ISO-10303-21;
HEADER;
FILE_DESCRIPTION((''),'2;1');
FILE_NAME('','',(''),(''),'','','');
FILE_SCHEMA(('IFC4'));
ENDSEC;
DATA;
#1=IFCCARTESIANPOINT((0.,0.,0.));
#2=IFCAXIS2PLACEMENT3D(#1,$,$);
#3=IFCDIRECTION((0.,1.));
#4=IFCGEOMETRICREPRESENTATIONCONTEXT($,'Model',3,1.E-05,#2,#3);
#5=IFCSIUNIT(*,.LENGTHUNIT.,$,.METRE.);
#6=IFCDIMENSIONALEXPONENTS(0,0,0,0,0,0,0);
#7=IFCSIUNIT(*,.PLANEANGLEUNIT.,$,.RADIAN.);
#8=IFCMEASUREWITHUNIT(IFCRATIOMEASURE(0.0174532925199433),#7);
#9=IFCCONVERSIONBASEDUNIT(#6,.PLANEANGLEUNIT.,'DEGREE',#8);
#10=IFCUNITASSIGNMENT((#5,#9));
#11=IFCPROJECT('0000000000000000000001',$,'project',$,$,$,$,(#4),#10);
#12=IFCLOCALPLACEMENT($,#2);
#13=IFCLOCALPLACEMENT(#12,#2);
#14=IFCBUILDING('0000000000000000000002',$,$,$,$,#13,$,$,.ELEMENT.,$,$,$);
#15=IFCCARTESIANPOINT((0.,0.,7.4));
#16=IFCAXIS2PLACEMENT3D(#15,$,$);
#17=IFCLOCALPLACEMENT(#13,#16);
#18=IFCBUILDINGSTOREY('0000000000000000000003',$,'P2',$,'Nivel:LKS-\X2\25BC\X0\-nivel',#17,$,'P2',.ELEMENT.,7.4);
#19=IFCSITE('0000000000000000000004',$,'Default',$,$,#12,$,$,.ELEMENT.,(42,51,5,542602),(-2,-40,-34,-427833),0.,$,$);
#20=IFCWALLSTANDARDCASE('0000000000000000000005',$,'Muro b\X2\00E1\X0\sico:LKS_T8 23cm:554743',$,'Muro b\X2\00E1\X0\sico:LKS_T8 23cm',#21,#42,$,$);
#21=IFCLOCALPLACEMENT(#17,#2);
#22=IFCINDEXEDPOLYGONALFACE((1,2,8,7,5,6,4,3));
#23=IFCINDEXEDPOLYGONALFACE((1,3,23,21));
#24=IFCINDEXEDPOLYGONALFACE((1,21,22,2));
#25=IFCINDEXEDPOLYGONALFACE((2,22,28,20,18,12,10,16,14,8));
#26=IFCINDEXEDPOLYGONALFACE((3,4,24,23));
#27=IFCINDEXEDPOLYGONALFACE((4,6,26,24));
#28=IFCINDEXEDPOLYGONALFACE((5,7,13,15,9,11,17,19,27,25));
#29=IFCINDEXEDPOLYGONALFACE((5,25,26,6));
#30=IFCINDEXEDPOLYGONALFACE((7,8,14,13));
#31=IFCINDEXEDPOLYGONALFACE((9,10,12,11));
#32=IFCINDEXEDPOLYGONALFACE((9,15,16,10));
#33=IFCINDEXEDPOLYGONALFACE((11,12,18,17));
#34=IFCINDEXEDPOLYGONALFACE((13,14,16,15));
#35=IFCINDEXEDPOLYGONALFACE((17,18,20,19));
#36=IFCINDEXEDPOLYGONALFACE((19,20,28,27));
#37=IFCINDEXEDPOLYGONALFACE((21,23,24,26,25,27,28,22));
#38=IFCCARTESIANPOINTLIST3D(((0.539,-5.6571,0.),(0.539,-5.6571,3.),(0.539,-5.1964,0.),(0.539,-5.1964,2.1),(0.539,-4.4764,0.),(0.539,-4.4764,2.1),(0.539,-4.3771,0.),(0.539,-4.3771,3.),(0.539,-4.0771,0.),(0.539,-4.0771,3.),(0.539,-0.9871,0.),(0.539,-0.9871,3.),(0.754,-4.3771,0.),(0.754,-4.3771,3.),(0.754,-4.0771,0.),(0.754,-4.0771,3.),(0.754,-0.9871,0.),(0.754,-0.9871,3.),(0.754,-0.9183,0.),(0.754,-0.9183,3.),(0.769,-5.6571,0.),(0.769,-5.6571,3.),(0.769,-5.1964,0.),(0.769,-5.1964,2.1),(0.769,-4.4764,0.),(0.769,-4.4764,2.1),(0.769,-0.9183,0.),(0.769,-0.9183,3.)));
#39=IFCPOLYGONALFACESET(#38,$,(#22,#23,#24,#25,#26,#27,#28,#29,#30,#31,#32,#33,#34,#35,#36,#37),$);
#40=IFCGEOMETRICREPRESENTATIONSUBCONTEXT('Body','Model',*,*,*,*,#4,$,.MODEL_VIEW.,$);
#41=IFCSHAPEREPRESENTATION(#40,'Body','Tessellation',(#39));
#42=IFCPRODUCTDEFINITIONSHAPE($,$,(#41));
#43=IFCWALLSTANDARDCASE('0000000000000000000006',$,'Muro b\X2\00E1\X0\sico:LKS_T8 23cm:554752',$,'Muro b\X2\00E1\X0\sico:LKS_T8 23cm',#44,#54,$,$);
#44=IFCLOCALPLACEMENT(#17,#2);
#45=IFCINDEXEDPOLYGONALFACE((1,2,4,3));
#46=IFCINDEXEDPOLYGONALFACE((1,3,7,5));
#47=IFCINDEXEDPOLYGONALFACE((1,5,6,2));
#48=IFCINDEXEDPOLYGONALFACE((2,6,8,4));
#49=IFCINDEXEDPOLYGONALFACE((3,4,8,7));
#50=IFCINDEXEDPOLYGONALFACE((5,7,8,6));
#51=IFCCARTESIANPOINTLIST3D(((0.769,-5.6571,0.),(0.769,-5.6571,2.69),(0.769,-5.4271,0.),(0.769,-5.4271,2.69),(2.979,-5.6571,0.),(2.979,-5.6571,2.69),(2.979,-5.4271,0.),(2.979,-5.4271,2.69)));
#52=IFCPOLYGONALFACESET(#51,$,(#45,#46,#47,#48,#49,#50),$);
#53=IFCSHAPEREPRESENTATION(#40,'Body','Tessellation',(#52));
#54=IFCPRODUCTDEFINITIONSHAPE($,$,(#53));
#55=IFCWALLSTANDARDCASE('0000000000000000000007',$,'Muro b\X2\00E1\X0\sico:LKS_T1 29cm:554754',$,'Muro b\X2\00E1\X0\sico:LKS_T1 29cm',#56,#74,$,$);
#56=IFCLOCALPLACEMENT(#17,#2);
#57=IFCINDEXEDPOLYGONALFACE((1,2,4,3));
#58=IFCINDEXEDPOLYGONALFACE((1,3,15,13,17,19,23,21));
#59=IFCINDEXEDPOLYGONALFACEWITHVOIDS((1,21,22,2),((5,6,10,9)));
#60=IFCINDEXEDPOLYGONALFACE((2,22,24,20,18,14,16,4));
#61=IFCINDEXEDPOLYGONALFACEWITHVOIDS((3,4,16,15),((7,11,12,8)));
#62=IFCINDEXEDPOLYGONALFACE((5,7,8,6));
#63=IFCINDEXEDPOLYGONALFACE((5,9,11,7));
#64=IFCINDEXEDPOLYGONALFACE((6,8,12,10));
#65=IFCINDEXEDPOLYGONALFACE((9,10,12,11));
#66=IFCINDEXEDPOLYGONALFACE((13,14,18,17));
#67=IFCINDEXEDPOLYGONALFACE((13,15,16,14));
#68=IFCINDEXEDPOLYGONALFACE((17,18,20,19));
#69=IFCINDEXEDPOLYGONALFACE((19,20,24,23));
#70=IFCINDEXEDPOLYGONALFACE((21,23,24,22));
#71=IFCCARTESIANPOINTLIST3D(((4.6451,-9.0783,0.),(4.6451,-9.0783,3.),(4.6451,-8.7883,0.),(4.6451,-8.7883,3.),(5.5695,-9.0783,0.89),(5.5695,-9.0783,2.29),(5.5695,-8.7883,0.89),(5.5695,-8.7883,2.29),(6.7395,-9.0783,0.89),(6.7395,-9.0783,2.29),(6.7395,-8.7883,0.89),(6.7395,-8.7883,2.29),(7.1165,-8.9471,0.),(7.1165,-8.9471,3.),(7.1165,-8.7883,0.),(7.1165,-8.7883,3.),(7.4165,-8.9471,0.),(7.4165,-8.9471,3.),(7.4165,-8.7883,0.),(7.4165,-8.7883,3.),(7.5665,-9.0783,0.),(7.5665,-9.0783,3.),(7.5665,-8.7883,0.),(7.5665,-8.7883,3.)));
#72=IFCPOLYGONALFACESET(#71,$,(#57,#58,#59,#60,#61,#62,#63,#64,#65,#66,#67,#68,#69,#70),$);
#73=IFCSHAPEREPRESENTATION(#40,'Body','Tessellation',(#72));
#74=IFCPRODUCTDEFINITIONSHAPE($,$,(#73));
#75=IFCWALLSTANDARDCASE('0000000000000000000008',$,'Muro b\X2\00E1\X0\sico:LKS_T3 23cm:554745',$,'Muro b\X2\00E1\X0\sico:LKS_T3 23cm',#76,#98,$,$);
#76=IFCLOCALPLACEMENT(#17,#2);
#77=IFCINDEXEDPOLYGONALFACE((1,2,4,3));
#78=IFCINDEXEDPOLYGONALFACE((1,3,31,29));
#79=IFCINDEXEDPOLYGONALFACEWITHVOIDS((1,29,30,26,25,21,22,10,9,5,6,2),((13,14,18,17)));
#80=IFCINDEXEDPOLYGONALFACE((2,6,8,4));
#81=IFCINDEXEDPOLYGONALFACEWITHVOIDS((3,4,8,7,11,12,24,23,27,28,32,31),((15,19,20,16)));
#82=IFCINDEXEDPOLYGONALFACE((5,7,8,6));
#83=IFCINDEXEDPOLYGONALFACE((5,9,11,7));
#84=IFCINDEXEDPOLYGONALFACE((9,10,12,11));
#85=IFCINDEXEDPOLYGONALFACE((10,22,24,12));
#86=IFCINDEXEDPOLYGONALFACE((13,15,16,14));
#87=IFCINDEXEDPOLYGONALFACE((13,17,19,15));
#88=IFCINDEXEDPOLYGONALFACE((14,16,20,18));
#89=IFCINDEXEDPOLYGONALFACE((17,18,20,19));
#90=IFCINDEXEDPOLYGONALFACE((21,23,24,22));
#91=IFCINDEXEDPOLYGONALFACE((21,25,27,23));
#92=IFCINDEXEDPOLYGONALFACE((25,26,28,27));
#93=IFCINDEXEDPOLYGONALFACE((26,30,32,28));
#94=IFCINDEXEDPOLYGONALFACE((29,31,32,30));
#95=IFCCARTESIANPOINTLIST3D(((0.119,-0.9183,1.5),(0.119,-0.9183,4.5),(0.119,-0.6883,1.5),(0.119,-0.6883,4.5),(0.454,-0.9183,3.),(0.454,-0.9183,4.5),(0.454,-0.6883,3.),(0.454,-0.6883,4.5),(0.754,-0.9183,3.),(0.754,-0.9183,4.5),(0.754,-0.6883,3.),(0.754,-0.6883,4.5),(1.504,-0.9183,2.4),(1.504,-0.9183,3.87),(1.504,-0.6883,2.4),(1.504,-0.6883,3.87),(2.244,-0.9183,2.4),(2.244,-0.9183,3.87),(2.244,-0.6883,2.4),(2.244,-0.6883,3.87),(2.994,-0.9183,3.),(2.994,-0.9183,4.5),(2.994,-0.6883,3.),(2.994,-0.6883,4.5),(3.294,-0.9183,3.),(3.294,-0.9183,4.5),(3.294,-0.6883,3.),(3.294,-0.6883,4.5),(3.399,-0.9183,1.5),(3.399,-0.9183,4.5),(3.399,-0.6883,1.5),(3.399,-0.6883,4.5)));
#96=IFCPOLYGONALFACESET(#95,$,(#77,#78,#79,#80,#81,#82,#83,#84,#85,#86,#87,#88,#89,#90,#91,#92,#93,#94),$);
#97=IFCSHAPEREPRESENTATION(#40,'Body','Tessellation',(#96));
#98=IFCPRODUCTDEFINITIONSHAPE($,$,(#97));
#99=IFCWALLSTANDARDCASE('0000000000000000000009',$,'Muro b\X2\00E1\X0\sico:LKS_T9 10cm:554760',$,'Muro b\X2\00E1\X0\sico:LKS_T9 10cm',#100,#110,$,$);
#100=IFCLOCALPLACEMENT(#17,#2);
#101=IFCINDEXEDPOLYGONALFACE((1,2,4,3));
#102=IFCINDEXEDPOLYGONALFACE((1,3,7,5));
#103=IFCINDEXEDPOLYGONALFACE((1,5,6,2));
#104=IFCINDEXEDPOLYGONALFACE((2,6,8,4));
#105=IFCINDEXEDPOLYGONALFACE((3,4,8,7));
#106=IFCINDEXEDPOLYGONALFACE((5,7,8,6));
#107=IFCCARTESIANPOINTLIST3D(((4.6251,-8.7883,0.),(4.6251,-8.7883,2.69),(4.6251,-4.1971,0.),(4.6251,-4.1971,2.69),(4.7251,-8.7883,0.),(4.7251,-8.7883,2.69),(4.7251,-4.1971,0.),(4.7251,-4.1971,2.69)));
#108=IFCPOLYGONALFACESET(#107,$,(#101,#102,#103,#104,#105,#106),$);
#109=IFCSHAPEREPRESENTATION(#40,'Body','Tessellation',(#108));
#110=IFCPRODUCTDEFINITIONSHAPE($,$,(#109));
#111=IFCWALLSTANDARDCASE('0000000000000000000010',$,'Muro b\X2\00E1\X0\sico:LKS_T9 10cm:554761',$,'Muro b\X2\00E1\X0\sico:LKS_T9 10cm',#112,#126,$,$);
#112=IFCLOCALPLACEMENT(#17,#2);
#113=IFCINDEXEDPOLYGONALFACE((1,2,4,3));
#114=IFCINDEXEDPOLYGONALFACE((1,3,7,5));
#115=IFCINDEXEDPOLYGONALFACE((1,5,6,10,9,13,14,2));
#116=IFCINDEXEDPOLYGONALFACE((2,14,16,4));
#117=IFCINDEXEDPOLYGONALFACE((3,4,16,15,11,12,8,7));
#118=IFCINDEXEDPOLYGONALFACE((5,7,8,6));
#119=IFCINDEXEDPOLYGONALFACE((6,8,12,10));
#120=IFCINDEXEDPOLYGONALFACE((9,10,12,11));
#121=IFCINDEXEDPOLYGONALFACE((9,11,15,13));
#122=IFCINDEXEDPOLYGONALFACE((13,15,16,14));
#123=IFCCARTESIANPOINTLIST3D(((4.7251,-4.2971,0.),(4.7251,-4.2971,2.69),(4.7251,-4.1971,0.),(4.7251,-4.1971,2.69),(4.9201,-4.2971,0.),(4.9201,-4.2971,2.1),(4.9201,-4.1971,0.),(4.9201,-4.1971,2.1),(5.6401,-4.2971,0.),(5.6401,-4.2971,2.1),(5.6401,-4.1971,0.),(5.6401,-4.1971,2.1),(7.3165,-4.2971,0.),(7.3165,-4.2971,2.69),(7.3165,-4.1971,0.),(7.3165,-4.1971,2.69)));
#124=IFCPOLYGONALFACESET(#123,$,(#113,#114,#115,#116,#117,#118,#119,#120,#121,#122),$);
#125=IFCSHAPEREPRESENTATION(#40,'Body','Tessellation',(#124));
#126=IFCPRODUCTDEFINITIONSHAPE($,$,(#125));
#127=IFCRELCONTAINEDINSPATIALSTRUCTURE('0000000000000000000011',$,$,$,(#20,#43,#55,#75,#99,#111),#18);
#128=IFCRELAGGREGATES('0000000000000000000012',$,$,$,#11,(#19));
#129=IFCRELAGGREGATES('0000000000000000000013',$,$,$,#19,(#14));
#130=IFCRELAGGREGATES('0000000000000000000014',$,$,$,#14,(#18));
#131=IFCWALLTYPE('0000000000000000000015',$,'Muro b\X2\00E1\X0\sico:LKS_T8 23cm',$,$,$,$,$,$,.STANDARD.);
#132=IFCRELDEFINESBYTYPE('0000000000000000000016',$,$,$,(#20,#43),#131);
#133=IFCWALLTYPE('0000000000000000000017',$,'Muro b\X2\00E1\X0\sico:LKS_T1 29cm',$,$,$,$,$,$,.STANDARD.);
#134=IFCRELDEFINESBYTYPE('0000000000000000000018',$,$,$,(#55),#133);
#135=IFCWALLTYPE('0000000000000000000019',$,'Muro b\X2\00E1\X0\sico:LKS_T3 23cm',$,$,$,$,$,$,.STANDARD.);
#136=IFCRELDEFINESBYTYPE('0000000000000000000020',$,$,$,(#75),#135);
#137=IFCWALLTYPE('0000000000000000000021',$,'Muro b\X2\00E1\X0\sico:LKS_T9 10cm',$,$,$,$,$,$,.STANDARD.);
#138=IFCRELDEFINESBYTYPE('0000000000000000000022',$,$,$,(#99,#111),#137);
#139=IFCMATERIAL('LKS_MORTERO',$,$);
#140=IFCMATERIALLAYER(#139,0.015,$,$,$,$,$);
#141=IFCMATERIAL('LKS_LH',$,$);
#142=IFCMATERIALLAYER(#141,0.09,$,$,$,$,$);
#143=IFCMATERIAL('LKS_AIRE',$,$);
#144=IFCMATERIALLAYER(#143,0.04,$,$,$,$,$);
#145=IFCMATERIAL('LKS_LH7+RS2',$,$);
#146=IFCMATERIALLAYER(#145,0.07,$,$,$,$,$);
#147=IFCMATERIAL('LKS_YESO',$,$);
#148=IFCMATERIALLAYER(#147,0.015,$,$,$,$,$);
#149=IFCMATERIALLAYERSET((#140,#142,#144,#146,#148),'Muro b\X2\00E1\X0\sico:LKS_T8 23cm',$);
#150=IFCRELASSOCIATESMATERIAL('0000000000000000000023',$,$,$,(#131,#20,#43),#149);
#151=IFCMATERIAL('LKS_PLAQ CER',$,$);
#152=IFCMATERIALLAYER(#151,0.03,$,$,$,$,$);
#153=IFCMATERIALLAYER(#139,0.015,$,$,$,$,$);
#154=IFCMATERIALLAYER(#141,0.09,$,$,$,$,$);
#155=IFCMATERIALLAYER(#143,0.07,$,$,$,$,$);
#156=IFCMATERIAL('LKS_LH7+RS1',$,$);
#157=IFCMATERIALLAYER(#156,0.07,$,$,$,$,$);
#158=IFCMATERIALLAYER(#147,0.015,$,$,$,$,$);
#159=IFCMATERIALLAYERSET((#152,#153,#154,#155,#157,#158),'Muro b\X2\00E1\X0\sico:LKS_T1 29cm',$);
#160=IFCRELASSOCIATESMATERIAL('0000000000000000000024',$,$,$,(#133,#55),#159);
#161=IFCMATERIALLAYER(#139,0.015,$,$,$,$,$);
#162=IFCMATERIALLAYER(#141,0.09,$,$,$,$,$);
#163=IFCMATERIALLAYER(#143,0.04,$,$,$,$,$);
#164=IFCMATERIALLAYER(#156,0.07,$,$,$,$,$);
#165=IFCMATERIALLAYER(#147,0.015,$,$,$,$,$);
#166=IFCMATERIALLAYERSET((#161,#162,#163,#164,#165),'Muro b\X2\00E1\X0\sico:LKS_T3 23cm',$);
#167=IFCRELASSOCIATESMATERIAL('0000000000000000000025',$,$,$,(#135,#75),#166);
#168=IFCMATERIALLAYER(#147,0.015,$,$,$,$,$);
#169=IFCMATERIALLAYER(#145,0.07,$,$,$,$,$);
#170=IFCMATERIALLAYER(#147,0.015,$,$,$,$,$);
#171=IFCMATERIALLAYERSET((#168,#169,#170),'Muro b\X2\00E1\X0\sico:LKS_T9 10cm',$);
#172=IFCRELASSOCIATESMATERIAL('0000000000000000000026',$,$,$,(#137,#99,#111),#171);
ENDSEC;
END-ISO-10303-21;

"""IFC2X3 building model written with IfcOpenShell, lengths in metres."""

from ifc_helpers import new_model, entity, si_unit, converted_unit, direction, frame, frame_2d, origin, place, context, subcontext, project, spatial, polyline, rectangle, extrude, clip, bounded_halfspace, material, layer, layer_set, layer_usage, type_object, element, save


model = new_model("IFC2X3")

# Units and contexts
model_context = context("Model", 3, precision=1e-05, world=origin(), true_north=direction((0.0, 1.0)))
body_context = subcontext(model_context, "Body", "Model", "MODEL_VIEW")
ifc_project = project(units=[si_unit("LENGTHUNIT", "METRE"), converted_unit("PLANEANGLEUNIT", "DEGREE", entity("IfcRatioMeasure", 0.0174532925199433), si_unit("PLANEANGLEUNIT", "RADIAN"), dimensions=[0, 0, 0, 0, 0, 0, 0])], contexts=[model_context])

# Site, building, storey
site_placement = place(None, origin())
site = spatial("IfcSite", under=ifc_project, at=site_placement, Name="Default", CompositionType="ELEMENT", RefLatitude=(42, 51, 5, 542602), RefLongitude=(-2, -40, -34, -427833), RefElevation=0.0)
building_placement = place(site_placement, origin())
building = spatial("IfcBuilding", under=site, at=building_placement, CompositionType="ELEMENT")
storey_placement = place(building_placement, frame((0.0, 0.0, 7.4)))
storey = spatial("IfcBuildingStorey", under=building, at=storey_placement, Name="P2", ObjectType="Nivel:LKS-▼-nivel", LongName="P2", CompositionType="ELEMENT", Elevation=7.4)

# Shared definitions
ifc_material_1 = material(Name="LKS_MORTERO")
ifc_layer_1 = layer(ifc_material_1, 0.015)
ifc_material_2 = material(Name="LKS_LH")
ifc_layer_2 = layer(ifc_material_2, 0.09)
ifc_material_3 = material(Name="LKS_AIRE")
ifc_layer_3 = layer(ifc_material_3, 0.04)
ifc_material_4 = material(Name="LKS_LH7+RS2")
ifc_layer_4 = layer(ifc_material_4, 0.07)
ifc_material_5 = material(Name="LKS_YESO")
ifc_layer_5 = layer(ifc_material_5, 0.015)
ifc_layer_set_1 = layer_set([ifc_layer_1, ifc_layer_2, ifc_layer_3, ifc_layer_4, ifc_layer_5], Name="Muro básico:LKS_T8 23cm")
wall_type_1 = type_object("IfcWallType", Name="Muro básico:LKS_T8 23cm", PredefinedType="STANDARD", material=ifc_layer_set_1)

# Wall, openings
ifc_layer_usage_1 = layer_usage(ifc_layer_set_1, "AXIS2", "POSITIVE", -0.115)
wall_1_placement = place(storey_placement, frame((0.654, -5.6571, 0.0), z_axis=(0.0, 0.0, 1.0), x_axis=(0.0, 1.0, 0.0)))
wall_1 = element("IfcWallStandardCase", 1, at=wall_1_placement, inside=storey, type_object=wall_type_1, material=ifc_layer_usage_1, Name="Muro básico:LKS_T8 23cm:554743", ObjectType="Muro básico:LKS_T8 23cm", context=body_context, shape_type="Clipping", body=[
    clip(clip(extrude(rectangle(XDim=4.7389, YDim=0.23, at=frame_2d((2.3694, 0.0), x_axis=(-1.0, 0.0))), origin(), (0.0, 0.0, 1.0), 3.0), bounded_halfspace(frame((4.67, -0.1, 0.0), z_axis=(0.0, -1.0, 0.0), x_axis=(0.0, 0.0, -1.0)), True, frame((4.67, -0.1, 0.0), z_axis=(0.0, -1.0, 0.0), x_axis=(0.0, 0.0, -1.0)), polyline([(0.0, 0.0), (0.0, 0.0689), (-1.5, 0.0689), (-3.0, 0.0689), (-3.0, 0.0), (0.0, 0.0)]))), bounded_halfspace(frame((4.67, -0.1, 3.0), z_axis=(-1.0, 0.0, 0.0), x_axis=(0.0, 0.0, -1.0)), True, frame((4.67, -0.1, 3.0), z_axis=(-1.0, 0.0, 0.0), x_axis=(0.0, 0.0, -1.0)), polyline([(0.0, 0.0), (0.0, -0.015), (0.0, -0.215), (3.0, -0.215), (3.0, 0.0), (0.0, 0.0)]))),
])
opening_1_placement = place(storey_placement, frame((0.654, -5.6571, 0.0), z_axis=(0.0, 0.0, 1.0), x_axis=(0.0, 1.0, 0.0)))
element("IfcOpeningElement", 2, at=opening_1_placement, cuts=wall_1, ObjectType="Opening", context=body_context, shape_type="SweptSolid", body=[
    extrude(rectangle(XDim=3.0, YDim=0.215, at=frame_2d((0.234, 0.0215), x_axis=(1.0, 0.0))), frame((1.28, -0.014, 1.734), z_axis=(1.0, 0.0, 0.0), x_axis=(0.0, 0.0, -1.0)), (0.0, 0.0, 1.0), 0.3),
])
opening_2_placement = place(wall_1_placement, origin())
element("IfcOpeningElement", 3, at=opening_2_placement, cuts=wall_1, ObjectType="Opening", context=body_context, shape_type="SweptSolid", body=[
    extrude(rectangle(XDim=2.1, YDim=0.72, at=frame_2d((0.0, 0.0), x_axis=(1.0, 0.0))), frame((0.8208, -1.639, 4.05), z_axis=(0.0, 1.0, 0.0), x_axis=(0.0, 0.0, 1.0)), (0.0, 0.0, 1.0), 3.048),
])
opening_3_placement = place(wall_1_placement, frame((0.4608, -0.115, 0.0)))
element("IfcOpeningElement", 4, at=opening_3_placement, cuts=wall_1, ObjectType="Opening", context=body_context, shape_type="SweptSolid", body=[
    extrude(rectangle(XDim=2.1, YDim=0.72, at=frame_2d((1.05, 0.36), x_axis=(1.0, 0.0))), frame((0.0, 0.0, 0.0), z_axis=(0.0, 1.0, 0.0), x_axis=(0.0, 0.0, 1.0)), (0.0, 0.0, 1.0), 0.23),
])

# Wall
ifc_layer_usage_2 = layer_usage(ifc_layer_set_1, "AXIS2", "POSITIVE", -0.115)
wall_2_placement = place(storey_placement, frame((2.979, -5.5421, 0.0), z_axis=(0.0, 0.0, 1.0), x_axis=(-1.0, 0.0, 0.0)))
element("IfcWallStandardCase", 5, at=wall_2_placement, inside=storey, type_object=wall_type_1, material=ifc_layer_usage_2, Name="Muro básico:LKS_T8 23cm:554752", ObjectType="Muro básico:LKS_T8 23cm", context=body_context, shape_type="SweptSolid", body=[
    extrude(rectangle(XDim=2.21, YDim=0.23, at=frame_2d((1.105, 0.0), x_axis=(-1.0, 0.0))), origin(), (0.0, 0.0, 1.0), 2.69),
])

# Wall, openings
ifc_material_6 = material(Name="LKS_PLAQ CER")
ifc_layer_6 = layer(ifc_material_6, 0.03)
ifc_layer_7 = layer(ifc_material_1, 0.015)
ifc_layer_8 = layer(ifc_material_2, 0.09)
ifc_layer_9 = layer(ifc_material_3, 0.07)
ifc_material_7 = material(Name="LKS_LH7+RS1")
ifc_layer_10 = layer(ifc_material_7, 0.07)
ifc_layer_11 = layer(ifc_material_5, 0.015)
ifc_layer_set_2 = layer_set([ifc_layer_6, ifc_layer_7, ifc_layer_8, ifc_layer_9, ifc_layer_10, ifc_layer_11], Name="Muro básico:LKS_T1 29cm")
ifc_layer_usage_3 = layer_usage(ifc_layer_set_2, "AXIS2", "POSITIVE", -0.145)
wall_type_2 = type_object("IfcWallType", Name="Muro básico:LKS_T1 29cm", PredefinedType="STANDARD", material=ifc_layer_set_2)
wall_3_placement = place(storey_placement, frame((4.6451, -8.9333, 0.0)))
wall_3 = element("IfcWallStandardCase", 6, at=wall_3_placement, inside=storey, type_object=wall_type_2, material=ifc_layer_usage_3, Name="Muro básico:LKS_T1 29cm:554754", ObjectType="Muro básico:LKS_T1 29cm", context=body_context, shape_type="SweptSolid", body=[
    extrude(rectangle(XDim=2.9215, YDim=0.29, at=frame_2d((1.4607, 0.0), x_axis=(-1.0, 0.0))), origin(), (0.0, 0.0, 1.0), 3.0),
])
opening_4_placement = place(storey_placement, frame((4.6451, -8.9333, 0.0)))
element("IfcOpeningElement", 7, at=opening_4_placement, cuts=wall_3, ObjectType="Opening", context=body_context, shape_type="SweptSolid", body=[
    extrude(rectangle(XDim=3.0, YDim=0.1589, at=frame_2d((0.234, 0.0159), x_axis=(1.0, 0.0))), frame((2.4715, 0.0497, 1.734), z_axis=(1.0, 0.0, 0.0), x_axis=(0.0, 0.0, -1.0)), (0.0, 0.0, 1.0), 0.3),
])
opening_5_placement = place(wall_3_placement, frame((0.9244, -0.145, 0.89)))
element("IfcOpeningElement", 8, at=opening_5_placement, cuts=wall_3, ObjectType="Opening", context=body_context, shape_type="SweptSolid", body=[
    extrude(rectangle(XDim=1.4, YDim=1.17, at=frame_2d((0.7, 0.585), x_axis=(1.0, 0.0))), frame((0.0, 0.0, 0.0), z_axis=(0.0, 1.0, 0.0), x_axis=(0.0, 0.0, 1.0)), (0.0, 0.0, 1.0), 0.29),
])

# Wall, opening
ifc_layer_12 = layer(ifc_material_1, 0.015)
ifc_layer_13 = layer(ifc_material_2, 0.09)
ifc_layer_14 = layer(ifc_material_3, 0.04)
ifc_layer_15 = layer(ifc_material_7, 0.07)
ifc_layer_16 = layer(ifc_material_5, 0.015)
ifc_layer_set_3 = layer_set([ifc_layer_12, ifc_layer_13, ifc_layer_14, ifc_layer_15, ifc_layer_16], Name="Muro básico:LKS_T3 23cm")
ifc_layer_usage_4 = layer_usage(ifc_layer_set_3, "AXIS2", "NEGATIVE", 0.115)
wall_type_3 = type_object("IfcWallType", Name="Muro básico:LKS_T3 23cm", PredefinedType="STANDARD", material=ifc_layer_set_3)
wall_4_placement = place(storey_placement, frame((3.399, -0.8033, 1.5), z_axis=(0.0, 0.0, 1.0), x_axis=(-1.0, 0.0, 0.0)))
wall_4 = element("IfcWallStandardCase", 9, at=wall_4_placement, inside=storey, type_object=wall_type_3, material=ifc_layer_usage_4, Name="Muro básico:LKS_T3 23cm:554745", ObjectType="Muro básico:LKS_T3 23cm", context=body_context, shape_type="Clipping", body=[
    clip(clip(extrude(rectangle(XDim=3.28, YDim=0.23, at=frame_2d((1.64, 0.0), x_axis=(-1.0, 0.0))), origin(), (0.0, 0.0, 1.0), 3.0), bounded_halfspace(frame((2.945, -0.115, 1.5), z_axis=(0.0, 0.0, -1.0), x_axis=(-1.0, 0.0, 0.0)), True, frame((2.945, -0.115, 1.5), z_axis=(0.0, 0.0, -1.0), x_axis=(-1.0, 0.0, 0.0)), polyline([(0.0, 0.0), (0.3, 0.0), (0.3, 0.23), (0.0, 0.23), (0.0, 0.0)]))), bounded_halfspace(frame((0.405, -0.115, 1.5), z_axis=(0.0, 0.0, -1.0), x_axis=(-1.0, 0.0, 0.0)), True, frame((0.405, -0.115, 1.5), z_axis=(0.0, 0.0, -1.0), x_axis=(-1.0, 0.0, 0.0)), polyline([(0.0, 0.0), (0.3, 0.0), (0.3, 0.23), (0.0, 0.23), (0.0, 0.0)]))),
])
opening_6_placement = place(wall_4_placement, frame((1.895, 0.115, 0.9)))
element("IfcOpeningElement", 10, at=opening_6_placement, cuts=wall_4, ObjectType="Opening", context=body_context, shape_type="SweptSolid", body=[
    extrude(rectangle(XDim=1.47, YDim=0.74, at=frame_2d((0.735, 0.37), x_axis=(1.0, 0.0))), frame((0.0, 0.0, 0.0), z_axis=(0.0, -1.0, 0.0), x_axis=(0.0, 0.0, 1.0)), (0.0, 0.0, 1.0), 0.23),
])

# Wall
ifc_layer_17 = layer(ifc_material_5, 0.015)
ifc_layer_18 = layer(ifc_material_4, 0.07)
ifc_layer_19 = layer(ifc_material_5, 0.015)
ifc_layer_set_4 = layer_set([ifc_layer_17, ifc_layer_18, ifc_layer_19], Name="Muro básico:LKS_T9 10cm")
ifc_layer_usage_5 = layer_usage(ifc_layer_set_4, "AXIS2", "NEGATIVE", 0.05)
wall_type_4 = type_object("IfcWallType", Name="Muro básico:LKS_T9 10cm", PredefinedType="STANDARD", material=ifc_layer_set_4)
wall_5_placement = place(storey_placement, frame((4.6751, -8.7883, 0.0), z_axis=(0.0, 0.0, 1.0), x_axis=(0.0, 1.0, 0.0)))
element("IfcWallStandardCase", 11, at=wall_5_placement, inside=storey, type_object=wall_type_4, material=ifc_layer_usage_5, Name="Muro básico:LKS_T9 10cm:554760", ObjectType="Muro básico:LKS_T9 10cm", context=body_context, shape_type="SweptSolid", body=[
    extrude(rectangle(XDim=4.5911, YDim=0.1, at=frame_2d((2.2956, 0.0), x_axis=(-1.0, 0.0))), origin(), (0.0, 0.0, 1.0), 2.69),
])

# Wall, opening
ifc_layer_usage_6 = layer_usage(ifc_layer_set_4, "AXIS2", "NEGATIVE", 0.05)
wall_6_placement = place(storey_placement, frame((4.7251, -4.2471, 0.0)))
wall_6 = element("IfcWallStandardCase", 12, at=wall_6_placement, inside=storey, type_object=wall_type_4, material=ifc_layer_usage_6, Name="Muro básico:LKS_T9 10cm:554761", ObjectType="Muro básico:LKS_T9 10cm", context=body_context, shape_type="Clipping", body=[
    clip(extrude(rectangle(XDim=2.5915, YDim=0.1, at=frame_2d((1.2957, 0.0), x_axis=(-1.0, 0.0))), origin(), (0.0, 0.0, 1.0), 2.69), bounded_halfspace(frame((2.5915, -0.05, 2.69), z_axis=(-1.0, 0.0, 0.0), x_axis=(0.0, 0.0, -1.0)), True, frame((2.5915, -0.05, 2.69), z_axis=(-1.0, 0.0, 0.0), x_axis=(0.0, 0.0, -1.0)), polyline([(0.0, 0.0), (0.0, -0.1), (2.69, -0.1), (2.69, 0.0), (0.0, 0.0)]))),
])
opening_7_placement = place(wall_6_placement, frame((0.915, 0.05, 0.0)))
element("IfcOpeningElement", 13, at=opening_7_placement, cuts=wall_6, ObjectType="Opening", context=body_context, shape_type="SweptSolid", body=[
    extrude(rectangle(XDim=2.1, YDim=0.72, at=frame_2d((1.05, 0.36), x_axis=(1.0, 0.0))), frame((0.0, 0.0, 0.0), z_axis=(0.0, -1.0, 0.0), x_axis=(0.0, 0.0, 1.0)), (0.0, 0.0, 1.0), 0.1),
])

save(model, "model.ifc")
